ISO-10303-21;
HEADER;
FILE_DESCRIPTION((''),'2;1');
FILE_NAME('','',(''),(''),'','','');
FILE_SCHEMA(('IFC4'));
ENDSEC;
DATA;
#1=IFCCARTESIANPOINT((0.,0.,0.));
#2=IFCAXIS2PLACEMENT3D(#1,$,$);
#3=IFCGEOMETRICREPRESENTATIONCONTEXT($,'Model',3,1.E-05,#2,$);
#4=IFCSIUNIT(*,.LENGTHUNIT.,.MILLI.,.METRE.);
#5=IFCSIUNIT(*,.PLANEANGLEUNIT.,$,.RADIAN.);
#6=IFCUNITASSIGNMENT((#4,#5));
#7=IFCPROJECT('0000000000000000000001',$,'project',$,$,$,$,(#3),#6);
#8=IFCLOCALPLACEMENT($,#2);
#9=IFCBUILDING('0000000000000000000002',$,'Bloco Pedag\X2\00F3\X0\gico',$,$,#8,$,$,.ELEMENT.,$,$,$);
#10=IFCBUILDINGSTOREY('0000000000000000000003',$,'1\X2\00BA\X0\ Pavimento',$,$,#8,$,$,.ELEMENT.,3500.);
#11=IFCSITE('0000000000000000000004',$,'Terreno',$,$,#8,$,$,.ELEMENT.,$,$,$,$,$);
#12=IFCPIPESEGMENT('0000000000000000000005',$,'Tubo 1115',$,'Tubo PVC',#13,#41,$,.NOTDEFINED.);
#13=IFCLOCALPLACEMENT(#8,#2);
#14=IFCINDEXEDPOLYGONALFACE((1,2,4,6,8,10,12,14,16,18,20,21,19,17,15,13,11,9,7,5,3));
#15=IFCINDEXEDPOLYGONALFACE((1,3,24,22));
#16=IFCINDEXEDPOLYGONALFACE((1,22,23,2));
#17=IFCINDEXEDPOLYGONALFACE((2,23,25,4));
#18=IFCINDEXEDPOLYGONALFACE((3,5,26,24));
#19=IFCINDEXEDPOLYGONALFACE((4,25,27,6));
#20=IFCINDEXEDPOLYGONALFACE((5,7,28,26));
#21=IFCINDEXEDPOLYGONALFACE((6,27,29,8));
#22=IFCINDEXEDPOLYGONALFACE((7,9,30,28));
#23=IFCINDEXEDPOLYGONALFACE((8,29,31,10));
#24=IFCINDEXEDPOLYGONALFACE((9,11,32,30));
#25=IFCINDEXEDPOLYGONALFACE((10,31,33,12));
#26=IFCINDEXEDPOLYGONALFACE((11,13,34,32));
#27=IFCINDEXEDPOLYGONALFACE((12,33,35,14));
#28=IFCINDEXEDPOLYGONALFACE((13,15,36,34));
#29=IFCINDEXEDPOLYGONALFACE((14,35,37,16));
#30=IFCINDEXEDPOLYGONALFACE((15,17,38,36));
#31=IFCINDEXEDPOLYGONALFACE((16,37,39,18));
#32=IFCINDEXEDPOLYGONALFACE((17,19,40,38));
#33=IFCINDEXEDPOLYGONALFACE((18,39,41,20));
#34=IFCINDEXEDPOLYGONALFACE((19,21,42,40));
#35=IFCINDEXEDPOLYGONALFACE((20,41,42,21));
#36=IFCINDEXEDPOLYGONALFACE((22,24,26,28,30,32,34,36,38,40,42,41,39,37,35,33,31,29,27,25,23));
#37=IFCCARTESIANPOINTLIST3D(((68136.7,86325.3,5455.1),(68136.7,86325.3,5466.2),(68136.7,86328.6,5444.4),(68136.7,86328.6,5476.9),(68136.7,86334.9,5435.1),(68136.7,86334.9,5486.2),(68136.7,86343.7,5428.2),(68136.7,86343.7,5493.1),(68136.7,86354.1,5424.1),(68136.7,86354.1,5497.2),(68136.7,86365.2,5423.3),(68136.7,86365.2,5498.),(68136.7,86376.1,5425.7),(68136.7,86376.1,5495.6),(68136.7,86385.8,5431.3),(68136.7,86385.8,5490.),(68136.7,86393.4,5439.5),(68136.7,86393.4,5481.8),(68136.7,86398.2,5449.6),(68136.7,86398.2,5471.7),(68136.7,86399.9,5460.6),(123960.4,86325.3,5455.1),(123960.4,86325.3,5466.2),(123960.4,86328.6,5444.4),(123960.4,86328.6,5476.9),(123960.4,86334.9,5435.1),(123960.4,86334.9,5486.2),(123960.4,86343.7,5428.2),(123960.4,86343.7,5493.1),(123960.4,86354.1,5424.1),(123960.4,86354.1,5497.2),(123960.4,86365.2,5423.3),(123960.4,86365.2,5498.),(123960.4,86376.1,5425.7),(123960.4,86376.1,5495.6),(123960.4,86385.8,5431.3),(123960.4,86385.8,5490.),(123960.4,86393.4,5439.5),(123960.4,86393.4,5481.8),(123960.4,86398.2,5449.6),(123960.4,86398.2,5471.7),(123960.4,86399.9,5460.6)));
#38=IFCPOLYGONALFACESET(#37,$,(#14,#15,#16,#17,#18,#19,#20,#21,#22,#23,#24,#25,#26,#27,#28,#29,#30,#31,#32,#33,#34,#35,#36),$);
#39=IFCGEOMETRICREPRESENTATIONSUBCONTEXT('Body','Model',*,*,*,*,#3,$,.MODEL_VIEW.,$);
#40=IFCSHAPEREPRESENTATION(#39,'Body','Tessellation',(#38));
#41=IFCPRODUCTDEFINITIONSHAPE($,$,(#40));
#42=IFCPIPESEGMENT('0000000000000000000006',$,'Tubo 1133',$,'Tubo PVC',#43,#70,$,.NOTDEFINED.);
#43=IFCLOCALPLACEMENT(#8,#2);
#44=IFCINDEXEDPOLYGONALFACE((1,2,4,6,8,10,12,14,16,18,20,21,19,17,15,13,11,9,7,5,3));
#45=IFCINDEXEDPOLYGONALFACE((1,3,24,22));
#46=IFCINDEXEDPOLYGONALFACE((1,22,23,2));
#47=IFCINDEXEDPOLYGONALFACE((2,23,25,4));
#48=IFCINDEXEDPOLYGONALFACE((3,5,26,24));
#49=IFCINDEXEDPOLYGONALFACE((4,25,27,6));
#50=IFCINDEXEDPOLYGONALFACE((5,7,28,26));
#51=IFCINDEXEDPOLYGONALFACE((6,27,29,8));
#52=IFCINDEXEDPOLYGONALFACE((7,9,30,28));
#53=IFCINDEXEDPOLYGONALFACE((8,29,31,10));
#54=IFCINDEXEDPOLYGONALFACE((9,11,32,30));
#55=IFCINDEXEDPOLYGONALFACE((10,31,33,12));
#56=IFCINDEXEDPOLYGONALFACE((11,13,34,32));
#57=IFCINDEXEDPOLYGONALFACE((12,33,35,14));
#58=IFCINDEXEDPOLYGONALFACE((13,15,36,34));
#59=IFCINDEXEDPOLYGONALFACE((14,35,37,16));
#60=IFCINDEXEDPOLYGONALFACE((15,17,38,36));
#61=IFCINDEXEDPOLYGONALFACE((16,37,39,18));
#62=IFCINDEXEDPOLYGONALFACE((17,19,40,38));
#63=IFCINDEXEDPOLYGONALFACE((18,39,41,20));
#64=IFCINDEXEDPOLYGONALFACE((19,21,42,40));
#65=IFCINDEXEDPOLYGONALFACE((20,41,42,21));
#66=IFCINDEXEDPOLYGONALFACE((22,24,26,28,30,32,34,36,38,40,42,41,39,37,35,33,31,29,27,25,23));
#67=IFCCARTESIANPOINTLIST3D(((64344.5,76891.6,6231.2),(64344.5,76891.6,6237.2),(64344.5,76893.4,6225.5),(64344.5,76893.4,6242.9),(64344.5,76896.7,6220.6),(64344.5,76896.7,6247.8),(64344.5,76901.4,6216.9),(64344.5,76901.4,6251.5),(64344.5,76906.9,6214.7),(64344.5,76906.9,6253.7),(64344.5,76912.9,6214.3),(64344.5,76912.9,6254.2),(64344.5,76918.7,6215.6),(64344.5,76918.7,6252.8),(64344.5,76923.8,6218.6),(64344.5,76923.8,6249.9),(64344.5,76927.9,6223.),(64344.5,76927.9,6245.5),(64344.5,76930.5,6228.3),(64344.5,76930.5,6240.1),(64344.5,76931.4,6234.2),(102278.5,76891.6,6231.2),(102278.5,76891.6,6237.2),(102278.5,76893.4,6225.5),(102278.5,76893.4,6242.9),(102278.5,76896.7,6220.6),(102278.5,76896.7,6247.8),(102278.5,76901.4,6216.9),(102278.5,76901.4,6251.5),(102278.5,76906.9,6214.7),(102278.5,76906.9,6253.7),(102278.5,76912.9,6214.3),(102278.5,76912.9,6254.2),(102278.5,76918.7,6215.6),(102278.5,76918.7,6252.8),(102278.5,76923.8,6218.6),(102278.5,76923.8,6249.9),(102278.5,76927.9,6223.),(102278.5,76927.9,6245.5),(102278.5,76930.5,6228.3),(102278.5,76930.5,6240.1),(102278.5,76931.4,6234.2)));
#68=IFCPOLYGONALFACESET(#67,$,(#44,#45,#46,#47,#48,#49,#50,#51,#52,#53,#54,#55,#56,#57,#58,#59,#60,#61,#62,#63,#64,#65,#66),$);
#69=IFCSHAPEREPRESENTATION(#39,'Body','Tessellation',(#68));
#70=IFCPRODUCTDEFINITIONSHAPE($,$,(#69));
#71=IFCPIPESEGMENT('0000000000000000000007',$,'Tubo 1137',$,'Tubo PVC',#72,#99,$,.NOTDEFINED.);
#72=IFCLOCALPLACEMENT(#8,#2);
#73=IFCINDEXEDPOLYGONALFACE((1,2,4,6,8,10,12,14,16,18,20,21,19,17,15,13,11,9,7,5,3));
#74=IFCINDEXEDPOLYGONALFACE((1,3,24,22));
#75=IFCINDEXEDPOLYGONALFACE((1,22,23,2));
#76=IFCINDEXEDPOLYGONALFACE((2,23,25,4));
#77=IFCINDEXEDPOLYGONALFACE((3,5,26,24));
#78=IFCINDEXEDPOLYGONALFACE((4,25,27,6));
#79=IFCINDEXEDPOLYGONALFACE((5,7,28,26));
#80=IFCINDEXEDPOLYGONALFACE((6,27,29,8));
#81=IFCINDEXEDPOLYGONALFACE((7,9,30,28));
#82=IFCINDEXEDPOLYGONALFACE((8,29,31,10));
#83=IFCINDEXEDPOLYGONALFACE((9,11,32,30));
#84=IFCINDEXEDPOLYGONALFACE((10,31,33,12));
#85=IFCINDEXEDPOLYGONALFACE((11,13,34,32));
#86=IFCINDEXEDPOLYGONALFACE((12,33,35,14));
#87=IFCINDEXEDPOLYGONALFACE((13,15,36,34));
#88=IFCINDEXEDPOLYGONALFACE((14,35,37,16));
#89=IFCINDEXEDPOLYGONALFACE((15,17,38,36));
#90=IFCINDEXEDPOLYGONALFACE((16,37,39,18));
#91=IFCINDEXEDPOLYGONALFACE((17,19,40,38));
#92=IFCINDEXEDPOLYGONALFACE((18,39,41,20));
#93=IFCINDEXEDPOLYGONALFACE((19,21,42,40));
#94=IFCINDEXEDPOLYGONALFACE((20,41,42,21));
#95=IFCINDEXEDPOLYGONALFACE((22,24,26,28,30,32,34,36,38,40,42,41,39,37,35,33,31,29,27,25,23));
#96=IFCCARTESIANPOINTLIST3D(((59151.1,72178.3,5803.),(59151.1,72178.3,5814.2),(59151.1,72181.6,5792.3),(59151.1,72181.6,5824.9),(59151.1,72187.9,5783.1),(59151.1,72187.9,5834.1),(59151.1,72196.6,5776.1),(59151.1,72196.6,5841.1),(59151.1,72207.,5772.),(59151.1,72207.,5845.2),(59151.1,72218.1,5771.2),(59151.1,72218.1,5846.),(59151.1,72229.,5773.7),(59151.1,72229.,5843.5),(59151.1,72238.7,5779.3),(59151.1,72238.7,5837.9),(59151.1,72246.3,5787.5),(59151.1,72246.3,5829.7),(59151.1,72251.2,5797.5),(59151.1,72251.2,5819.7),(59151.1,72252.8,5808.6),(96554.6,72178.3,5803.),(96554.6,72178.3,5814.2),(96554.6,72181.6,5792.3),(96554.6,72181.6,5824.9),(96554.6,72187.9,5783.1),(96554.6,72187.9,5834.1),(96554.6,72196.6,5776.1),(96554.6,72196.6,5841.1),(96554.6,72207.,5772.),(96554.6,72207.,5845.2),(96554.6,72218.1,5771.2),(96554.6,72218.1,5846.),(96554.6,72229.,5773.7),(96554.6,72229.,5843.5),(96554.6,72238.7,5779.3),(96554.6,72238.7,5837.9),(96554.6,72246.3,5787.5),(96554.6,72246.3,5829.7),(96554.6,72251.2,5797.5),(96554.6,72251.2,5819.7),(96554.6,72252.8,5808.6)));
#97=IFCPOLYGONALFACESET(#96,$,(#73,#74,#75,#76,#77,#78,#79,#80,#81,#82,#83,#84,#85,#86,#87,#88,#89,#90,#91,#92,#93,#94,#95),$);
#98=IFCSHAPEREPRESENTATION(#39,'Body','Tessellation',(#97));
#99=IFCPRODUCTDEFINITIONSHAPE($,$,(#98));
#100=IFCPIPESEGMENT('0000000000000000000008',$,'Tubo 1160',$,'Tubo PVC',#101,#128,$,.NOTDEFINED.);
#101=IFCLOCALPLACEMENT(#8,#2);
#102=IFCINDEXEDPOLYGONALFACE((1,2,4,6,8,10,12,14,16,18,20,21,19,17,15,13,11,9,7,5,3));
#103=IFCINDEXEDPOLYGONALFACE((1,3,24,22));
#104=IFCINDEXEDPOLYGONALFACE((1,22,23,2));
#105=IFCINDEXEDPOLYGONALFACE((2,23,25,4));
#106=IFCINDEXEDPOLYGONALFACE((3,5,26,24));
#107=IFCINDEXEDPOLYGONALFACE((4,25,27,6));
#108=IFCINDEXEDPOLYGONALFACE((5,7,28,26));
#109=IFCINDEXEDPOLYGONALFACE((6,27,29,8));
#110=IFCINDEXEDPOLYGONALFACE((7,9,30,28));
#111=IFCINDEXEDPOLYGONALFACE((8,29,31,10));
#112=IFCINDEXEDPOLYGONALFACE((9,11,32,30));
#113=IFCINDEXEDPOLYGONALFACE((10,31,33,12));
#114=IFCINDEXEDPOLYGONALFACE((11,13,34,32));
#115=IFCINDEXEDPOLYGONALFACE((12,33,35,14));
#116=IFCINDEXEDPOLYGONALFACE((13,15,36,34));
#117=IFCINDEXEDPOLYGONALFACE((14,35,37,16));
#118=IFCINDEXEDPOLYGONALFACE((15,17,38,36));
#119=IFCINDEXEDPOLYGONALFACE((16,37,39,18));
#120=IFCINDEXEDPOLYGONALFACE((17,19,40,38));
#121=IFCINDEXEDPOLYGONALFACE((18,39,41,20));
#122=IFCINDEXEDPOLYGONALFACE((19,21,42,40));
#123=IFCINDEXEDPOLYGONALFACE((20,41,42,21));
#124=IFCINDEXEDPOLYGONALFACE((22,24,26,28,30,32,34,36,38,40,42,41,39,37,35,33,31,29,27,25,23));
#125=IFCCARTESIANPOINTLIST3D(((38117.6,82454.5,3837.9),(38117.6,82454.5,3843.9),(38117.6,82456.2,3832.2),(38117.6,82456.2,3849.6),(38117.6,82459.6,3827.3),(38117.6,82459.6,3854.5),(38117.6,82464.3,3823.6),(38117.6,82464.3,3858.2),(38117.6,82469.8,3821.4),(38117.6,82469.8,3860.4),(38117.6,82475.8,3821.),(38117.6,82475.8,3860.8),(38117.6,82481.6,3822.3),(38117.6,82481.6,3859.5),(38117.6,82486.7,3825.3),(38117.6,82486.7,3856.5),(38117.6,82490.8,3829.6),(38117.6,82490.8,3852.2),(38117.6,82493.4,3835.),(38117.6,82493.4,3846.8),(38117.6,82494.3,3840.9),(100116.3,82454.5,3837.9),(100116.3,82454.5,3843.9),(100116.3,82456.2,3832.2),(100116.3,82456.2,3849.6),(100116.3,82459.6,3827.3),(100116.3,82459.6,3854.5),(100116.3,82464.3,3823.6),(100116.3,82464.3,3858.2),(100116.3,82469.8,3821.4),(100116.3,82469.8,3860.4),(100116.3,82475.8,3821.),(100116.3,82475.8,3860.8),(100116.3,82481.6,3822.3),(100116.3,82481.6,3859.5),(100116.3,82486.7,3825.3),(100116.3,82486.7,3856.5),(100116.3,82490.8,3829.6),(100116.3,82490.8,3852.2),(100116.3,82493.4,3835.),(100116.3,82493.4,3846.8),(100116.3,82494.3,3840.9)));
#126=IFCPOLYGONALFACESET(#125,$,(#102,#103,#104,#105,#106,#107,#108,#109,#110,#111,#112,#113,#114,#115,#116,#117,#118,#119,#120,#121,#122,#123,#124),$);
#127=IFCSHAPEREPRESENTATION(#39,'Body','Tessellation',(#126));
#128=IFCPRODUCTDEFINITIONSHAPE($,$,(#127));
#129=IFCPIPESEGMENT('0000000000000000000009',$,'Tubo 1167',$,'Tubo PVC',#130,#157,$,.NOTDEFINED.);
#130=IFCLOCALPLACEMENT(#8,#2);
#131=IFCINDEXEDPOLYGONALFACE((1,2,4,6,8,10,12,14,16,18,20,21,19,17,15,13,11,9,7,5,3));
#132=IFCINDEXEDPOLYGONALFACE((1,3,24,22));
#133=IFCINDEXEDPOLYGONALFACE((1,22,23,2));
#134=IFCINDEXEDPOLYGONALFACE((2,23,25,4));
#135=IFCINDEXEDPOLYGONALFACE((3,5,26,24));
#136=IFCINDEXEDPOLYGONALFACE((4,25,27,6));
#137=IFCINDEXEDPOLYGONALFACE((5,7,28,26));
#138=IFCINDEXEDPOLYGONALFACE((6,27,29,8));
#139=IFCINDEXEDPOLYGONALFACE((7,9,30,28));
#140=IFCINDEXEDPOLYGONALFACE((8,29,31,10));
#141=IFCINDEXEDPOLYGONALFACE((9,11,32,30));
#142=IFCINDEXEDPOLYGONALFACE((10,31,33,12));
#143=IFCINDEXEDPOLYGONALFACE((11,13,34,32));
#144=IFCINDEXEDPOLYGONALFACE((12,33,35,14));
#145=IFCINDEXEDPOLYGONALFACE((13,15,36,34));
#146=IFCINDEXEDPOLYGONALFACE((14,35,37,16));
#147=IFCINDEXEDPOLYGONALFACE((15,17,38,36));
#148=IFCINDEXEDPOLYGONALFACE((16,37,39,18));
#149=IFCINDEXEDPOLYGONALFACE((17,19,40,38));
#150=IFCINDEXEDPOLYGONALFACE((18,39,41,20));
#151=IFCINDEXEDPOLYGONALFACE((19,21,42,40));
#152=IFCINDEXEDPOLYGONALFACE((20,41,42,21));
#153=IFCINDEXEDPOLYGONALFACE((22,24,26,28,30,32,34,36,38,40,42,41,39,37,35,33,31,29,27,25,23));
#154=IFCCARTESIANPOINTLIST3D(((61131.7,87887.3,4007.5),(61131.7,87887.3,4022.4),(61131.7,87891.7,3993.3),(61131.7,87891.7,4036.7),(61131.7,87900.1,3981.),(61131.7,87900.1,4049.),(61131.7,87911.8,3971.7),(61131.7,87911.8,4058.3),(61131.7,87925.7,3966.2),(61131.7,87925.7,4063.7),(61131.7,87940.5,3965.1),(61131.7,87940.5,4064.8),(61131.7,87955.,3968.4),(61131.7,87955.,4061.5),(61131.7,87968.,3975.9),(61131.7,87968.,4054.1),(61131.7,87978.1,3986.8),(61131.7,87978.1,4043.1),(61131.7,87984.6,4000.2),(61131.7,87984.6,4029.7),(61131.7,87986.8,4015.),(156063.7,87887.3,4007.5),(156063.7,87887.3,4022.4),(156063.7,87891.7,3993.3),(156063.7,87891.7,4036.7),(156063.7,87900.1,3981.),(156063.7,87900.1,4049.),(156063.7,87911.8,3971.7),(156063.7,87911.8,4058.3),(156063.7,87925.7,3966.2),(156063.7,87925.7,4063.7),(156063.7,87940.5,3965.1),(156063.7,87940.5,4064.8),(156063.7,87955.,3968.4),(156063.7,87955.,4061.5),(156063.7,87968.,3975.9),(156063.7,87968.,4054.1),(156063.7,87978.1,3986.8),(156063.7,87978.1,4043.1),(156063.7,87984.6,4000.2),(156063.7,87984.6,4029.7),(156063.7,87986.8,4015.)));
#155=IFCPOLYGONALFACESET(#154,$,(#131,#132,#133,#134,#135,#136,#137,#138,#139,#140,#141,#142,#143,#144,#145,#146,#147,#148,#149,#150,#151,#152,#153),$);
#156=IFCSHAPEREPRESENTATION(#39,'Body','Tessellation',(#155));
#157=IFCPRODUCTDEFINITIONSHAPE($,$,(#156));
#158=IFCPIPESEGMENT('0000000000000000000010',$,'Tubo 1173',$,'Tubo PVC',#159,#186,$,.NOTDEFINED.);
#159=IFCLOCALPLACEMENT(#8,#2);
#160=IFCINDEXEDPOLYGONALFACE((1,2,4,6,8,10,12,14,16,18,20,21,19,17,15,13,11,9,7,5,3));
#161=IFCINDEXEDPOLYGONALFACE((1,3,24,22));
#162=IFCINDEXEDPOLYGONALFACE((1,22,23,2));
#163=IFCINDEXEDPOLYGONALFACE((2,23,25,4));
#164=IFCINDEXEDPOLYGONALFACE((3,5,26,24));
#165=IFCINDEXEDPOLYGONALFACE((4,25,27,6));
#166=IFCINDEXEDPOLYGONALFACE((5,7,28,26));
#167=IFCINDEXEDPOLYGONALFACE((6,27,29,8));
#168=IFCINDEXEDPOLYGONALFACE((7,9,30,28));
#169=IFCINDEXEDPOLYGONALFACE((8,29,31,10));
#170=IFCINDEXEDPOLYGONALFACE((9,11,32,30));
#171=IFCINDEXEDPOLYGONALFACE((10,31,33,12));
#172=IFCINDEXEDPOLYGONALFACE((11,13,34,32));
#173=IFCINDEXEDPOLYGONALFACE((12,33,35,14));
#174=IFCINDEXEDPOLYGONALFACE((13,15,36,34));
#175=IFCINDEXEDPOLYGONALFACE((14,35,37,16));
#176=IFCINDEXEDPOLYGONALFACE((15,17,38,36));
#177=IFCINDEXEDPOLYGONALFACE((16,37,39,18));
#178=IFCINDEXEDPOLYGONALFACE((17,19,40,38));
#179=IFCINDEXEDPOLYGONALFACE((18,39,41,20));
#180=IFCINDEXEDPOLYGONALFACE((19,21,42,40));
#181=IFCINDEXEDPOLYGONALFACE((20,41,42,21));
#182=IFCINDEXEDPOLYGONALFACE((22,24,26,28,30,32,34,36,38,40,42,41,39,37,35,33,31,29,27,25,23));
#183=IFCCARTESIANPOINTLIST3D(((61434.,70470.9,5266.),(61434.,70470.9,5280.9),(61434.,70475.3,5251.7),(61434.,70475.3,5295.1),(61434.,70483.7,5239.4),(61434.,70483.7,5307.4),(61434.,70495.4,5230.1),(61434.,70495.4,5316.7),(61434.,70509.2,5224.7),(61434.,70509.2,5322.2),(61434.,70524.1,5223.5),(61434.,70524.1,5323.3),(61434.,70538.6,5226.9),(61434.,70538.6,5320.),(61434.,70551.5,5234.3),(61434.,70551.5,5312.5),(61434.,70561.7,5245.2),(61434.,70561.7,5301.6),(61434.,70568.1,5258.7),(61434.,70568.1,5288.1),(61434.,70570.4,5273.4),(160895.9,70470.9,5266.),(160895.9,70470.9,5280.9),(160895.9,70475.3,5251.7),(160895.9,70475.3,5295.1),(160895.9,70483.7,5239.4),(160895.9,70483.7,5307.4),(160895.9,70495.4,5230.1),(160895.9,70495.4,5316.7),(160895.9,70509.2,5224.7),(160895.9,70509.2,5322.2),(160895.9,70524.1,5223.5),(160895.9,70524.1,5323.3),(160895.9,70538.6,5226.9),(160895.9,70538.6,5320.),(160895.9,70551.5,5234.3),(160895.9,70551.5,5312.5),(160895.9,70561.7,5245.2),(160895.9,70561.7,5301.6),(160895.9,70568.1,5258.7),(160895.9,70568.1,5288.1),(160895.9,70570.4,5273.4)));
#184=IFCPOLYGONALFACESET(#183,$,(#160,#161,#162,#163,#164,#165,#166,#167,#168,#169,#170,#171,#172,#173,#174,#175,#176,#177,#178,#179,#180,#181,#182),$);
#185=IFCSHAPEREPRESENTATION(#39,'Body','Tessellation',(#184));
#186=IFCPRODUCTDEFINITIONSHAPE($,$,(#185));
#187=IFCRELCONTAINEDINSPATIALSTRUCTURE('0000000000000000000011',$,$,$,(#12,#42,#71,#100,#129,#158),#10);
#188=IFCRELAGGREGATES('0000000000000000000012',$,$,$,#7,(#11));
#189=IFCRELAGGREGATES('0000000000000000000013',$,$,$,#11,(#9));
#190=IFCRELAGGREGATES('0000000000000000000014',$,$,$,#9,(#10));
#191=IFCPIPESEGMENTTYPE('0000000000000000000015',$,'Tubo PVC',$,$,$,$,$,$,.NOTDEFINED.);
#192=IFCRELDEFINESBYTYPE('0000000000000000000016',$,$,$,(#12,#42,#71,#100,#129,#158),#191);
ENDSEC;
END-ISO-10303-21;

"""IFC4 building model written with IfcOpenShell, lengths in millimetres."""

from ifc_helpers import new_model, si_unit, frame, origin, origin_2d, place, context, subcontext, project, spatial, circle, extrude, type_object, element, save


model = new_model("IFC4")

# Units and contexts
model_context = context("Model", 3, precision=1e-05, world=origin())
body_context = subcontext(model_context, "Body", "Model", "MODEL_VIEW")
ifc_project = project(units=[si_unit("LENGTHUNIT", "METRE", prefix="MILLI"), si_unit("PLANEANGLEUNIT", "RADIAN")], contexts=[model_context])

# Site, building, storey
placement = place(None, origin())
site = spatial("IfcSite", under=ifc_project, at=placement, Name="Terreno", CompositionType="ELEMENT")
building = spatial("IfcBuilding", under=site, at=placement, Name="Bloco Pedagógico", CompositionType="ELEMENT")
storey = spatial("IfcBuildingStorey", under=building, at=placement, Name="1º Pavimento", CompositionType="ELEMENT", Elevation=3500.0)

# Pipe segments
pipe_segment_type = type_object("IfcPipeSegmentType", Name="Tubo PVC", PredefinedType="NOTDEFINED")
pipe_segment_1_placement = place(None, frame((68136.7, 86362.4, 5460.6), z_axis=(1.0, 0.0, 0.0), x_axis=(0.0, 1.0, 0.0)))
element("IfcPipeSegment", 1, at=pipe_segment_1_placement, inside=storey, type_object=pipe_segment_type, Name="Tubo 1115", ObjectType="Tubo PVC", PredefinedType="NOTDEFINED", context=body_context, shape_type="SweptSolid", body=[
    extrude(circle(Radius=37.5, at=origin_2d()), None, (0.0, 0.0, 1.0), 55823.7),
])
pipe_segment_2_placement = place(None, frame((64344.5, 76911.4, 6234.2), z_axis=(1.0, 0.0, 0.0), x_axis=(0.0, 1.0, 0.0)))
element("IfcPipeSegment", 2, at=pipe_segment_2_placement, inside=storey, type_object=pipe_segment_type, Name="Tubo 1133", ObjectType="Tubo PVC", PredefinedType="NOTDEFINED", context=body_context, shape_type="SweptSolid", body=[
    extrude(circle(Radius=20.0, at=origin_2d()), None, (0.0, 0.0, 1.0), 37933.9),
])
pipe_segment_3_placement = place(None, frame((59151.1, 72215.3, 5808.6), z_axis=(1.0, 0.0, 0.0), x_axis=(0.0, 1.0, 0.0)))
element("IfcPipeSegment", 3, at=pipe_segment_3_placement, inside=storey, type_object=pipe_segment_type, Name="Tubo 1137", ObjectType="Tubo PVC", PredefinedType="NOTDEFINED", context=body_context, shape_type="SweptSolid", body=[
    extrude(circle(Radius=37.5, at=origin_2d()), None, (0.0, 0.0, 1.0), 37403.5),
])
pipe_segment_4_placement = place(None, frame((38117.6, 82474.3, 3840.9), z_axis=(1.0, 0.0, 0.0), x_axis=(0.0, 1.0, 0.0)))
element("IfcPipeSegment", 4, at=pipe_segment_4_placement, inside=storey, type_object=pipe_segment_type, Name="Tubo 1160", ObjectType="Tubo PVC", PredefinedType="NOTDEFINED", context=body_context, shape_type="SweptSolid", body=[
    extrude(circle(Radius=20.0, at=origin_2d()), None, (0.0, 0.0, 1.0), 61998.7),
])
pipe_segment_5_placement = place(None, frame((61131.7, 87936.8, 4015.0), z_axis=(1.0, 0.0, 0.0), x_axis=(0.0, 1.0, 0.0)))
element("IfcPipeSegment", 5, at=pipe_segment_5_placement, inside=storey, type_object=pipe_segment_type, Name="Tubo 1167", ObjectType="Tubo PVC", PredefinedType="NOTDEFINED", context=body_context, shape_type="SweptSolid", body=[
    extrude(circle(Radius=50.0, at=origin_2d()), None, (0.0, 0.0, 1.0), 94931.9),
])
pipe_segment_6_placement = place(None, frame((61434.0, 70520.4, 5273.4), z_axis=(1.0, 0.0, 0.0), x_axis=(0.0, 1.0, 0.0)))
element("IfcPipeSegment", 6, at=pipe_segment_6_placement, inside=storey, type_object=pipe_segment_type, Name="Tubo 1173", ObjectType="Tubo PVC", PredefinedType="NOTDEFINED", context=body_context, shape_type="SweptSolid", body=[
    extrude(circle(Radius=50.0, at=origin_2d()), None, (0.0, 0.0, 1.0), 99461.9),
])

save(model, "model.ifc")
